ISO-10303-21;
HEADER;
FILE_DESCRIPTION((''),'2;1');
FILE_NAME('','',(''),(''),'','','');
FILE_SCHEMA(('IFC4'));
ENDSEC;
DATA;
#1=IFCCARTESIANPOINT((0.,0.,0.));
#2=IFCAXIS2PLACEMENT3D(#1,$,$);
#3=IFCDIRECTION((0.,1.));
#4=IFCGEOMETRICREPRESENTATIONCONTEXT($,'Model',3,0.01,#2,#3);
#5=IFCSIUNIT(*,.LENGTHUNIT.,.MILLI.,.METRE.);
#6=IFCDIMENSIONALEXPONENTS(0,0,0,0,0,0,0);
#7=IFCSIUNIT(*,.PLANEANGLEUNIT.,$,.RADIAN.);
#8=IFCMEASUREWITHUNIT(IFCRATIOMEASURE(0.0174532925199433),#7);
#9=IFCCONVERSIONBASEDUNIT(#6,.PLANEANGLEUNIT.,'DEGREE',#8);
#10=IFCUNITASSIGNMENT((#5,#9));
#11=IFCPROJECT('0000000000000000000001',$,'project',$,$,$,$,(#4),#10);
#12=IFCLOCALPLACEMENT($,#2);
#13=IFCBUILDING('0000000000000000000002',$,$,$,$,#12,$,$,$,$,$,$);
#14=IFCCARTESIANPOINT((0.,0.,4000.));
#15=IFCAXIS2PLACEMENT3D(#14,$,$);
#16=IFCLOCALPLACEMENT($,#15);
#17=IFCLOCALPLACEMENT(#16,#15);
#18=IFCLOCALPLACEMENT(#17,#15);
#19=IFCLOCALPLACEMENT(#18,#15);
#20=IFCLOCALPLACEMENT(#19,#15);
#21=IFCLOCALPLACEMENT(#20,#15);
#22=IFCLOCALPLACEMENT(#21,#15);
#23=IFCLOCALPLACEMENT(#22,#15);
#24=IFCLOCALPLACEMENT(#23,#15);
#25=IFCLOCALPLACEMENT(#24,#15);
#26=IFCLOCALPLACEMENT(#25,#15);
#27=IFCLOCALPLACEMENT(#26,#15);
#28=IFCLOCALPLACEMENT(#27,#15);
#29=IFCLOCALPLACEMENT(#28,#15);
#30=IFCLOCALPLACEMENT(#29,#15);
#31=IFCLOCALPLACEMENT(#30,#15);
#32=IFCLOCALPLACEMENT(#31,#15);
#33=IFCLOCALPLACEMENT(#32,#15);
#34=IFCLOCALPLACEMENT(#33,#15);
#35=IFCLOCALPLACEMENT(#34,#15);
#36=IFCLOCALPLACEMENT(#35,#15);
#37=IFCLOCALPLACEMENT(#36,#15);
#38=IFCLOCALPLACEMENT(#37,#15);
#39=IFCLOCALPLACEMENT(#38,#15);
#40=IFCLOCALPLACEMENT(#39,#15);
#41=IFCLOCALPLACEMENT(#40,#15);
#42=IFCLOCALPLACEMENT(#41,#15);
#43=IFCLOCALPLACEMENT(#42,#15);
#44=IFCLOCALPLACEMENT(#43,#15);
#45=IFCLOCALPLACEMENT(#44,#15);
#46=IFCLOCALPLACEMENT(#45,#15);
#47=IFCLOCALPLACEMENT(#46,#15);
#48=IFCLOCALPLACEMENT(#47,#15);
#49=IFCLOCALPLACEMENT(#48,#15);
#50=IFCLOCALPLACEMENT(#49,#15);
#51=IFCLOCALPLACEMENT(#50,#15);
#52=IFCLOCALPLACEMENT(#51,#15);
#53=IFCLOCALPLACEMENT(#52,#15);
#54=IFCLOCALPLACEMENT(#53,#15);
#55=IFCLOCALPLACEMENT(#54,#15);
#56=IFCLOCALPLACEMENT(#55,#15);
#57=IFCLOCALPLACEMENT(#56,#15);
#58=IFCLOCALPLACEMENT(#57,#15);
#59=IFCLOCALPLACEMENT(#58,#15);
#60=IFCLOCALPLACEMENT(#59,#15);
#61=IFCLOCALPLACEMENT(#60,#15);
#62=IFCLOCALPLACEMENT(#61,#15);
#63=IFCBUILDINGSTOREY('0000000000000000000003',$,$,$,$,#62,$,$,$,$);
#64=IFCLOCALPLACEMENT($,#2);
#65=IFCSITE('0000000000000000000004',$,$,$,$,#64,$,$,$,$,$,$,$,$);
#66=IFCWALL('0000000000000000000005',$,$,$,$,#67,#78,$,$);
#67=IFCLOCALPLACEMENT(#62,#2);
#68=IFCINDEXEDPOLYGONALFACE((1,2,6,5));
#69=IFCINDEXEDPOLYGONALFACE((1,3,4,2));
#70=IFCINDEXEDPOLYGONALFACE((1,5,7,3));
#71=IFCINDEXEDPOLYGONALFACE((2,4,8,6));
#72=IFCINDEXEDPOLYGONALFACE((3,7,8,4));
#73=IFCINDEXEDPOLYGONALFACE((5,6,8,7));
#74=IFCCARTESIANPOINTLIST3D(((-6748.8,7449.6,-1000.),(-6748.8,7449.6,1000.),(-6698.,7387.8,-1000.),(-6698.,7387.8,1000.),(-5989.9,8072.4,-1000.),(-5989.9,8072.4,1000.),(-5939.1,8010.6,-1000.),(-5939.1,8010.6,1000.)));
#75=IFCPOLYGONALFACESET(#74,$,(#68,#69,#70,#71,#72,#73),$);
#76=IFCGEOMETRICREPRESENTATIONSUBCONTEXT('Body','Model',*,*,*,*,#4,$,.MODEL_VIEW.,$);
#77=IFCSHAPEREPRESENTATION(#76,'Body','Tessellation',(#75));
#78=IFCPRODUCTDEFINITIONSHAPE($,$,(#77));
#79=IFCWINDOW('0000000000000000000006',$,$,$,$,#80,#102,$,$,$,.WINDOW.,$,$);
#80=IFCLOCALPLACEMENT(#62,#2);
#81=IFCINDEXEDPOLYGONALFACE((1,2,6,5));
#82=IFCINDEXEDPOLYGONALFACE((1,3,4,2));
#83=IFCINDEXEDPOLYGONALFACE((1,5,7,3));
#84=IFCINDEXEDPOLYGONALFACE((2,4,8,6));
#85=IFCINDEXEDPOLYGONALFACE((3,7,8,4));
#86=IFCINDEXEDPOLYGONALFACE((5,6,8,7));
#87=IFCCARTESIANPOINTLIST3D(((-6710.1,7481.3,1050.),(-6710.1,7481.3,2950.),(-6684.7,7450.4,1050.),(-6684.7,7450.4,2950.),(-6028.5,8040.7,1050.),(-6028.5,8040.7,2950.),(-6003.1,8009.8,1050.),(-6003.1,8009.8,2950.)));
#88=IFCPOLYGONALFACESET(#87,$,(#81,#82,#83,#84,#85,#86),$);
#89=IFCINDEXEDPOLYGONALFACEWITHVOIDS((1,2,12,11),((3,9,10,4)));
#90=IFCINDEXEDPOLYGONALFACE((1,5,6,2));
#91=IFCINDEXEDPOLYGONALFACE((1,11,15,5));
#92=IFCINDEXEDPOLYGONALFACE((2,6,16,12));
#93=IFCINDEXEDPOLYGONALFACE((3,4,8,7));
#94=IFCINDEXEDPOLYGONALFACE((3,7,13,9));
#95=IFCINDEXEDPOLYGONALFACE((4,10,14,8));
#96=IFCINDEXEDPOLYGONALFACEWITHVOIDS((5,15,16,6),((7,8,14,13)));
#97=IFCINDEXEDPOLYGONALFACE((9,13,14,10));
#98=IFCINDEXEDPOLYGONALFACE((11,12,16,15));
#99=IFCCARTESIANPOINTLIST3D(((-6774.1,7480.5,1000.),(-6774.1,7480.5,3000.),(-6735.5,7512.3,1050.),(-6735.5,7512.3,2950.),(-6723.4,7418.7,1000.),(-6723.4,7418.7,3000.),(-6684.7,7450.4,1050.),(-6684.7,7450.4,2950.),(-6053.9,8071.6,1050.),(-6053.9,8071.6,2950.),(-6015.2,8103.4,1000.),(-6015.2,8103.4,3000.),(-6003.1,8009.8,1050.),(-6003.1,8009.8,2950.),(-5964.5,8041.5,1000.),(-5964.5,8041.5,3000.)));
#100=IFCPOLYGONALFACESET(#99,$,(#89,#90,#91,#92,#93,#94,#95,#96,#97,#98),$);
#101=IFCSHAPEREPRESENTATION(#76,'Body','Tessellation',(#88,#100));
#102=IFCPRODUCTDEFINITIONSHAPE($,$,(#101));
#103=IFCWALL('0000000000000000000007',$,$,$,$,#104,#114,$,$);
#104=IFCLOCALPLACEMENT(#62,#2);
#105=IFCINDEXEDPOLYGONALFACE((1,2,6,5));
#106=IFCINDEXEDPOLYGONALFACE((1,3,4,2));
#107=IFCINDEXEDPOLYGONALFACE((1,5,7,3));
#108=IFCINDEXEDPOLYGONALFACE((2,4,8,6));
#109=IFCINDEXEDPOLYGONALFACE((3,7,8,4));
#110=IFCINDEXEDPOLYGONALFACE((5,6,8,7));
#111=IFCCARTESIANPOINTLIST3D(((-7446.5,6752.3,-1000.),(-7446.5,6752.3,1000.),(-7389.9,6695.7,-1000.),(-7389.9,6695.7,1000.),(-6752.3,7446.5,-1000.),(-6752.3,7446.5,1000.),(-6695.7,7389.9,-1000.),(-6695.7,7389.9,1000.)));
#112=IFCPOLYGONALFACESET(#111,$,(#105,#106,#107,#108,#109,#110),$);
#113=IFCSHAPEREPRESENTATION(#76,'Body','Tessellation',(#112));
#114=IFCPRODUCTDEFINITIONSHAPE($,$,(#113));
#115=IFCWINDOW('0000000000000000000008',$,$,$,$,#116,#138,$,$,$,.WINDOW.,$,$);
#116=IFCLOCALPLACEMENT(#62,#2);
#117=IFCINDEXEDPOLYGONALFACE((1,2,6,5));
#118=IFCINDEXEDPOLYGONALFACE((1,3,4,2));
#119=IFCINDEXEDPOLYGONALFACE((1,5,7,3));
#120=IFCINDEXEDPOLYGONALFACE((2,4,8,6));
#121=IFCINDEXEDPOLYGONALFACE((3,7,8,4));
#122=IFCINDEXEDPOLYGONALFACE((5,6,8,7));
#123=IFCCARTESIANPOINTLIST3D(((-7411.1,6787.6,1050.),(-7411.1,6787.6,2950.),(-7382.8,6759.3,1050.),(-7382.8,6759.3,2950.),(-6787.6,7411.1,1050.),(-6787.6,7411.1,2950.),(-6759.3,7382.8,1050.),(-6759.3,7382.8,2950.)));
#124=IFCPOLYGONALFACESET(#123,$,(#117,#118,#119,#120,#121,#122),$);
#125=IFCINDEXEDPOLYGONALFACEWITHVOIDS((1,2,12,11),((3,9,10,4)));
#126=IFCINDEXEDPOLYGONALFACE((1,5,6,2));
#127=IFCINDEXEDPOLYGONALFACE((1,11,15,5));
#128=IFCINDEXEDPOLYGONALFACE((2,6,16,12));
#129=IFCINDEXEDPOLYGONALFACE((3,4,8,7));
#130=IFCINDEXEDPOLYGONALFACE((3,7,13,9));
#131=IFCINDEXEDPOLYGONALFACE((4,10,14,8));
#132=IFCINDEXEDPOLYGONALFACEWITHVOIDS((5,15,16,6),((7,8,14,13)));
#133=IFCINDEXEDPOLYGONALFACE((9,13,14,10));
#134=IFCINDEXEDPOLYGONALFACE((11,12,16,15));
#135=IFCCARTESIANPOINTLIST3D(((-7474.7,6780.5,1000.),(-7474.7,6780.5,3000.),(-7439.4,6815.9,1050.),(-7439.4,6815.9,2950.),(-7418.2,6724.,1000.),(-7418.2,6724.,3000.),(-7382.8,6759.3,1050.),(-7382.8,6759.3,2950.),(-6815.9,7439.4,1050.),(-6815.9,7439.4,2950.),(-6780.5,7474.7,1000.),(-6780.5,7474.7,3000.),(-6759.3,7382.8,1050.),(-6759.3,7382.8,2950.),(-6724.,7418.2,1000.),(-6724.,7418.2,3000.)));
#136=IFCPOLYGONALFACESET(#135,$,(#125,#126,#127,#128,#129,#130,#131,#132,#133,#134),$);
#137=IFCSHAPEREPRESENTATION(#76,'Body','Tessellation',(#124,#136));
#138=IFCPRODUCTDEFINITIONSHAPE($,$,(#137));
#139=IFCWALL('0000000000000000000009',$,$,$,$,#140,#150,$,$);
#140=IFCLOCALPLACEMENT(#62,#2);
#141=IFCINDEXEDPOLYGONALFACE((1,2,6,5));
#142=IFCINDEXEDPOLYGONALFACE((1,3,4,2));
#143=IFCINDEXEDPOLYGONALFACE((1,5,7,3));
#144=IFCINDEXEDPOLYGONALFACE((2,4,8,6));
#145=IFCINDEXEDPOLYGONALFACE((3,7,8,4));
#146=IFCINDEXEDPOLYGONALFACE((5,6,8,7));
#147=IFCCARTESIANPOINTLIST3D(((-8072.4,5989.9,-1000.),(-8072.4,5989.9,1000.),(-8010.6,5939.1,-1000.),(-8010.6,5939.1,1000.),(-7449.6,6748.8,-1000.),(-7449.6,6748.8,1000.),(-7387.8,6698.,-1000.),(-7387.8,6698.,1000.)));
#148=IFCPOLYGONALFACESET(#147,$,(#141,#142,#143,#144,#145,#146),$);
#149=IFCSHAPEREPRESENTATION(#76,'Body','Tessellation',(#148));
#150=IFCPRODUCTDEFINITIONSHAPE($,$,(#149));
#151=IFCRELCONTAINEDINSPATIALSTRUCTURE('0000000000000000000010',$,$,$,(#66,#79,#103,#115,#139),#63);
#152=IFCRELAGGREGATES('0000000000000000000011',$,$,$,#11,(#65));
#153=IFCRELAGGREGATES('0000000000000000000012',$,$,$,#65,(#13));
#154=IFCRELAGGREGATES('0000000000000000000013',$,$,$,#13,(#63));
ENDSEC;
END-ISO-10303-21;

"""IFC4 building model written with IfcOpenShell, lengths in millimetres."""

from ifc_helpers import new_model, entity, si_unit, converted_unit, direction, frame, origin, origin_2d, place, context, subcontext, project, spatial, rectangle, extrude, element, save


model = new_model("IFC4")

# Units and contexts
model_context = context("Model", 3, precision=0.01, world=origin(), true_north=direction((0.0, 1.0)))
body_context = subcontext(model_context, "Body", "Model", "MODEL_VIEW")
ifc_project = project(units=[si_unit("LENGTHUNIT", "METRE", prefix="MILLI"), converted_unit("PLANEANGLEUNIT", "DEGREE", entity("IfcRatioMeasure", 0.0174532925199433), si_unit("PLANEANGLEUNIT", "RADIAN"), dimensions=[0, 0, 0, 0, 0, 0, 0])], contexts=[model_context])

# Site, building, storey
site_placement = place(None, origin())
site = spatial("IfcSite", under=ifc_project, at=site_placement)
building_placement = place(None, origin())
building = spatial("IfcBuilding", under=site, at=building_placement)
placement_1 = place(None, frame((0.0, 0.0, 4000.0)))
placement_2 = place(placement_1, frame((0.0, 0.0, 4000.0)))
placement_3 = place(placement_2, frame((0.0, 0.0, 4000.0)))
placement_4 = place(placement_3, frame((0.0, 0.0, 4000.0)))
placement_5 = place(placement_4, frame((0.0, 0.0, 4000.0)))
placement_6 = place(placement_5, frame((0.0, 0.0, 4000.0)))
placement_7 = place(placement_6, frame((0.0, 0.0, 4000.0)))
placement_8 = place(placement_7, frame((0.0, 0.0, 4000.0)))
placement_9 = place(placement_8, frame((0.0, 0.0, 4000.0)))
placement_10 = place(placement_9, frame((0.0, 0.0, 4000.0)))
placement_11 = place(placement_10, frame((0.0, 0.0, 4000.0)))
placement_12 = place(placement_11, frame((0.0, 0.0, 4000.0)))
placement_13 = place(placement_12, frame((0.0, 0.0, 4000.0)))
placement_14 = place(placement_13, frame((0.0, 0.0, 4000.0)))
placement_15 = place(placement_14, frame((0.0, 0.0, 4000.0)))
placement_16 = place(placement_15, frame((0.0, 0.0, 4000.0)))
placement_17 = place(placement_16, frame((0.0, 0.0, 4000.0)))
placement_18 = place(placement_17, frame((0.0, 0.0, 4000.0)))
placement_19 = place(placement_18, frame((0.0, 0.0, 4000.0)))
placement_20 = place(placement_19, frame((0.0, 0.0, 4000.0)))
placement_21 = place(placement_20, frame((0.0, 0.0, 4000.0)))
placement_22 = place(placement_21, frame((0.0, 0.0, 4000.0)))
placement_23 = place(placement_22, frame((0.0, 0.0, 4000.0)))
placement_24 = place(placement_23, frame((0.0, 0.0, 4000.0)))
placement_25 = place(placement_24, frame((0.0, 0.0, 4000.0)))
placement_26 = place(placement_25, frame((0.0, 0.0, 4000.0)))
placement_27 = place(placement_26, frame((0.0, 0.0, 4000.0)))
placement_28 = place(placement_27, frame((0.0, 0.0, 4000.0)))
placement_29 = place(placement_28, frame((0.0, 0.0, 4000.0)))
placement_30 = place(placement_29, frame((0.0, 0.0, 4000.0)))
placement_31 = place(placement_30, frame((0.0, 0.0, 4000.0)))
placement_32 = place(placement_31, frame((0.0, 0.0, 4000.0)))
placement_33 = place(placement_32, frame((0.0, 0.0, 4000.0)))
placement_34 = place(placement_33, frame((0.0, 0.0, 4000.0)))
placement_35 = place(placement_34, frame((0.0, 0.0, 4000.0)))
placement_36 = place(placement_35, frame((0.0, 0.0, 4000.0)))
placement_37 = place(placement_36, frame((0.0, 0.0, 4000.0)))
placement_38 = place(placement_37, frame((0.0, 0.0, 4000.0)))
placement_39 = place(placement_38, frame((0.0, 0.0, 4000.0)))
placement_40 = place(placement_39, frame((0.0, 0.0, 4000.0)))
placement_41 = place(placement_40, frame((0.0, 0.0, 4000.0)))
placement_42 = place(placement_41, frame((0.0, 0.0, 4000.0)))
placement_43 = place(placement_42, frame((0.0, 0.0, 4000.0)))
placement_44 = place(placement_43, frame((0.0, 0.0, 4000.0)))
placement_45 = place(placement_44, frame((0.0, 0.0, 4000.0)))
placement_46 = place(placement_45, frame((0.0, 0.0, 4000.0)))
storey_placement = place(placement_46, frame((0.0, 0.0, 4000.0)))
storey = spatial("IfcBuildingStorey", under=building, at=storey_placement)

# Shared definitions
cartesian_point_1 = entity("IfcCartesianPoint", [-440.9, -950.0])
shared_polyline = entity("IfcPolyline", [cartesian_point_1, entity("IfcCartesianPoint", [-440.9, 950.0]), entity("IfcCartesianPoint", [-440.9, 950.0]), entity("IfcCartesianPoint", [440.9, 950.0]), entity("IfcCartesianPoint", [440.9, 950.0]), entity("IfcCartesianPoint", [440.9, -950.0]), entity("IfcCartesianPoint", [440.9, -950.0]), entity("IfcCartesianPoint", [-440.9, -950.0]), cartesian_point_1])

# Wall
wall_1_placement = place(storey_placement, frame((-6343.9, 7730.1, -1000.0), z_axis=(0.0, 0.0, 1.0), x_axis=(-7730.104749, -6343.932579, 0.0)))
element("IfcWall", 1, at=wall_1_placement, inside=storey, context=body_context, shape_type="SweptSolid", body=[
    extrude(rectangle(XDim=981.7, YDim=80.0, at=origin_2d()), origin(), (0.0, 0.0, 1.0), 2000.0),
])

# Window
window_1_placement = place(storey_placement, frame((-6343.9, 7730.1, 2000.0), z_axis=(0.0, 0.0, 1.0), x_axis=(-7730.104749, -6343.932579, 0.0)))
cartesian_point_2 = entity("IfcCartesianPoint", [-490.9, -1000.0])
element("IfcWindow", 2, at=window_1_placement, inside=storey, PredefinedType="WINDOW", context=body_context, shape_type="SweptSolid", body=[
    entity("IfcExtrudedAreaSolid", entity("IfcArbitraryClosedProfileDef", "AREA", None, shared_polyline), entity("IfcAxis2Placement3D", entity("IfcCartesianPoint", [0.0, 0.0, 0.0]), entity("IfcDirection", [0.0, -1.0, 0.0]), entity("IfcDirection", [1.0, 0.0, 0.0])), entity("IfcDirection", [0.0, 0.0, 1.0]), 40.0),
    entity("IfcExtrudedAreaSolid", entity("IfcArbitraryProfileDefWithVoids", "AREA", None, entity("IfcPolyline", [cartesian_point_2, entity("IfcCartesianPoint", [-490.9, 1000.0]), entity("IfcCartesianPoint", [-490.9, 1000.0]), entity("IfcCartesianPoint", [490.9, 1000.0]), entity("IfcCartesianPoint", [490.9, 1000.0]), entity("IfcCartesianPoint", [490.9, -1000.0]), entity("IfcCartesianPoint", [490.9, -1000.0]), entity("IfcCartesianPoint", [-490.9, -1000.0]), cartesian_point_2]), [shared_polyline]), entity("IfcAxis2Placement3D", entity("IfcCartesianPoint", [0.0, 0.0, 0.0]), entity("IfcDirection", [0.0, -1.0, 0.0]), entity("IfcDirection", [1.0, 0.0, 0.0])), entity("IfcDirection", [0.0, 0.0, 1.0]), 80.0),
])

# Wall
wall_2_placement = place(storey_placement, frame((-7071.1, 7071.1, -1000.0), z_axis=(0.0, 0.0, 1.0), x_axis=(-7071.06777, -7071.067854, 0.0)))
element("IfcWall", 3, at=wall_2_placement, inside=storey, context=body_context, shape_type="SweptSolid", body=[
    extrude(rectangle(XDim=981.7, YDim=80.0, at=origin_2d()), origin(), (0.0, 0.0, 1.0), 2000.0),
])

# Window
window_2_placement = place(storey_placement, frame((-7071.1, 7071.1, 2000.0), z_axis=(0.0, 0.0, 1.0), x_axis=(-7071.06777, -7071.067854, 0.0)))
cartesian_point_3 = entity("IfcCartesianPoint", [-490.9, -1000.0])
element("IfcWindow", 4, at=window_2_placement, inside=storey, PredefinedType="WINDOW", context=body_context, shape_type="SweptSolid", body=[
    entity("IfcExtrudedAreaSolid", entity("IfcArbitraryClosedProfileDef", "AREA", None, shared_polyline), entity("IfcAxis2Placement3D", entity("IfcCartesianPoint", [0.0, 0.0, 0.0]), entity("IfcDirection", [0.0, -1.0, 0.0]), entity("IfcDirection", [1.0, 0.0, 0.0])), entity("IfcDirection", [0.0, 0.0, 1.0]), 40.0),
    entity("IfcExtrudedAreaSolid", entity("IfcArbitraryProfileDefWithVoids", "AREA", None, entity("IfcPolyline", [cartesian_point_3, entity("IfcCartesianPoint", [-490.9, 1000.0]), entity("IfcCartesianPoint", [-490.9, 1000.0]), entity("IfcCartesianPoint", [490.9, 1000.0]), entity("IfcCartesianPoint", [490.9, 1000.0]), entity("IfcCartesianPoint", [490.9, -1000.0]), entity("IfcCartesianPoint", [490.9, -1000.0]), entity("IfcCartesianPoint", [-490.9, -1000.0]), cartesian_point_3]), [shared_polyline]), entity("IfcAxis2Placement3D", entity("IfcCartesianPoint", [0.0, 0.0, 0.0]), entity("IfcDirection", [0.0, -1.0, 0.0]), entity("IfcDirection", [1.0, 0.0, 0.0])), entity("IfcDirection", [0.0, 0.0, 1.0]), 80.0),
])

# Wall
wall_3_placement = place(storey_placement, frame((-7730.1, 6343.9, -1000.0), z_axis=(0.0, 0.0, 1.0), x_axis=(-6343.932486, -7730.104825, 0.0)))
element("IfcWall", 5, at=wall_3_placement, inside=storey, context=body_context, shape_type="SweptSolid", body=[
    extrude(rectangle(XDim=981.7, YDim=80.0, at=origin_2d()), origin(), (0.0, 0.0, 1.0), 2000.0),
])

save(model, "model.ifc")
